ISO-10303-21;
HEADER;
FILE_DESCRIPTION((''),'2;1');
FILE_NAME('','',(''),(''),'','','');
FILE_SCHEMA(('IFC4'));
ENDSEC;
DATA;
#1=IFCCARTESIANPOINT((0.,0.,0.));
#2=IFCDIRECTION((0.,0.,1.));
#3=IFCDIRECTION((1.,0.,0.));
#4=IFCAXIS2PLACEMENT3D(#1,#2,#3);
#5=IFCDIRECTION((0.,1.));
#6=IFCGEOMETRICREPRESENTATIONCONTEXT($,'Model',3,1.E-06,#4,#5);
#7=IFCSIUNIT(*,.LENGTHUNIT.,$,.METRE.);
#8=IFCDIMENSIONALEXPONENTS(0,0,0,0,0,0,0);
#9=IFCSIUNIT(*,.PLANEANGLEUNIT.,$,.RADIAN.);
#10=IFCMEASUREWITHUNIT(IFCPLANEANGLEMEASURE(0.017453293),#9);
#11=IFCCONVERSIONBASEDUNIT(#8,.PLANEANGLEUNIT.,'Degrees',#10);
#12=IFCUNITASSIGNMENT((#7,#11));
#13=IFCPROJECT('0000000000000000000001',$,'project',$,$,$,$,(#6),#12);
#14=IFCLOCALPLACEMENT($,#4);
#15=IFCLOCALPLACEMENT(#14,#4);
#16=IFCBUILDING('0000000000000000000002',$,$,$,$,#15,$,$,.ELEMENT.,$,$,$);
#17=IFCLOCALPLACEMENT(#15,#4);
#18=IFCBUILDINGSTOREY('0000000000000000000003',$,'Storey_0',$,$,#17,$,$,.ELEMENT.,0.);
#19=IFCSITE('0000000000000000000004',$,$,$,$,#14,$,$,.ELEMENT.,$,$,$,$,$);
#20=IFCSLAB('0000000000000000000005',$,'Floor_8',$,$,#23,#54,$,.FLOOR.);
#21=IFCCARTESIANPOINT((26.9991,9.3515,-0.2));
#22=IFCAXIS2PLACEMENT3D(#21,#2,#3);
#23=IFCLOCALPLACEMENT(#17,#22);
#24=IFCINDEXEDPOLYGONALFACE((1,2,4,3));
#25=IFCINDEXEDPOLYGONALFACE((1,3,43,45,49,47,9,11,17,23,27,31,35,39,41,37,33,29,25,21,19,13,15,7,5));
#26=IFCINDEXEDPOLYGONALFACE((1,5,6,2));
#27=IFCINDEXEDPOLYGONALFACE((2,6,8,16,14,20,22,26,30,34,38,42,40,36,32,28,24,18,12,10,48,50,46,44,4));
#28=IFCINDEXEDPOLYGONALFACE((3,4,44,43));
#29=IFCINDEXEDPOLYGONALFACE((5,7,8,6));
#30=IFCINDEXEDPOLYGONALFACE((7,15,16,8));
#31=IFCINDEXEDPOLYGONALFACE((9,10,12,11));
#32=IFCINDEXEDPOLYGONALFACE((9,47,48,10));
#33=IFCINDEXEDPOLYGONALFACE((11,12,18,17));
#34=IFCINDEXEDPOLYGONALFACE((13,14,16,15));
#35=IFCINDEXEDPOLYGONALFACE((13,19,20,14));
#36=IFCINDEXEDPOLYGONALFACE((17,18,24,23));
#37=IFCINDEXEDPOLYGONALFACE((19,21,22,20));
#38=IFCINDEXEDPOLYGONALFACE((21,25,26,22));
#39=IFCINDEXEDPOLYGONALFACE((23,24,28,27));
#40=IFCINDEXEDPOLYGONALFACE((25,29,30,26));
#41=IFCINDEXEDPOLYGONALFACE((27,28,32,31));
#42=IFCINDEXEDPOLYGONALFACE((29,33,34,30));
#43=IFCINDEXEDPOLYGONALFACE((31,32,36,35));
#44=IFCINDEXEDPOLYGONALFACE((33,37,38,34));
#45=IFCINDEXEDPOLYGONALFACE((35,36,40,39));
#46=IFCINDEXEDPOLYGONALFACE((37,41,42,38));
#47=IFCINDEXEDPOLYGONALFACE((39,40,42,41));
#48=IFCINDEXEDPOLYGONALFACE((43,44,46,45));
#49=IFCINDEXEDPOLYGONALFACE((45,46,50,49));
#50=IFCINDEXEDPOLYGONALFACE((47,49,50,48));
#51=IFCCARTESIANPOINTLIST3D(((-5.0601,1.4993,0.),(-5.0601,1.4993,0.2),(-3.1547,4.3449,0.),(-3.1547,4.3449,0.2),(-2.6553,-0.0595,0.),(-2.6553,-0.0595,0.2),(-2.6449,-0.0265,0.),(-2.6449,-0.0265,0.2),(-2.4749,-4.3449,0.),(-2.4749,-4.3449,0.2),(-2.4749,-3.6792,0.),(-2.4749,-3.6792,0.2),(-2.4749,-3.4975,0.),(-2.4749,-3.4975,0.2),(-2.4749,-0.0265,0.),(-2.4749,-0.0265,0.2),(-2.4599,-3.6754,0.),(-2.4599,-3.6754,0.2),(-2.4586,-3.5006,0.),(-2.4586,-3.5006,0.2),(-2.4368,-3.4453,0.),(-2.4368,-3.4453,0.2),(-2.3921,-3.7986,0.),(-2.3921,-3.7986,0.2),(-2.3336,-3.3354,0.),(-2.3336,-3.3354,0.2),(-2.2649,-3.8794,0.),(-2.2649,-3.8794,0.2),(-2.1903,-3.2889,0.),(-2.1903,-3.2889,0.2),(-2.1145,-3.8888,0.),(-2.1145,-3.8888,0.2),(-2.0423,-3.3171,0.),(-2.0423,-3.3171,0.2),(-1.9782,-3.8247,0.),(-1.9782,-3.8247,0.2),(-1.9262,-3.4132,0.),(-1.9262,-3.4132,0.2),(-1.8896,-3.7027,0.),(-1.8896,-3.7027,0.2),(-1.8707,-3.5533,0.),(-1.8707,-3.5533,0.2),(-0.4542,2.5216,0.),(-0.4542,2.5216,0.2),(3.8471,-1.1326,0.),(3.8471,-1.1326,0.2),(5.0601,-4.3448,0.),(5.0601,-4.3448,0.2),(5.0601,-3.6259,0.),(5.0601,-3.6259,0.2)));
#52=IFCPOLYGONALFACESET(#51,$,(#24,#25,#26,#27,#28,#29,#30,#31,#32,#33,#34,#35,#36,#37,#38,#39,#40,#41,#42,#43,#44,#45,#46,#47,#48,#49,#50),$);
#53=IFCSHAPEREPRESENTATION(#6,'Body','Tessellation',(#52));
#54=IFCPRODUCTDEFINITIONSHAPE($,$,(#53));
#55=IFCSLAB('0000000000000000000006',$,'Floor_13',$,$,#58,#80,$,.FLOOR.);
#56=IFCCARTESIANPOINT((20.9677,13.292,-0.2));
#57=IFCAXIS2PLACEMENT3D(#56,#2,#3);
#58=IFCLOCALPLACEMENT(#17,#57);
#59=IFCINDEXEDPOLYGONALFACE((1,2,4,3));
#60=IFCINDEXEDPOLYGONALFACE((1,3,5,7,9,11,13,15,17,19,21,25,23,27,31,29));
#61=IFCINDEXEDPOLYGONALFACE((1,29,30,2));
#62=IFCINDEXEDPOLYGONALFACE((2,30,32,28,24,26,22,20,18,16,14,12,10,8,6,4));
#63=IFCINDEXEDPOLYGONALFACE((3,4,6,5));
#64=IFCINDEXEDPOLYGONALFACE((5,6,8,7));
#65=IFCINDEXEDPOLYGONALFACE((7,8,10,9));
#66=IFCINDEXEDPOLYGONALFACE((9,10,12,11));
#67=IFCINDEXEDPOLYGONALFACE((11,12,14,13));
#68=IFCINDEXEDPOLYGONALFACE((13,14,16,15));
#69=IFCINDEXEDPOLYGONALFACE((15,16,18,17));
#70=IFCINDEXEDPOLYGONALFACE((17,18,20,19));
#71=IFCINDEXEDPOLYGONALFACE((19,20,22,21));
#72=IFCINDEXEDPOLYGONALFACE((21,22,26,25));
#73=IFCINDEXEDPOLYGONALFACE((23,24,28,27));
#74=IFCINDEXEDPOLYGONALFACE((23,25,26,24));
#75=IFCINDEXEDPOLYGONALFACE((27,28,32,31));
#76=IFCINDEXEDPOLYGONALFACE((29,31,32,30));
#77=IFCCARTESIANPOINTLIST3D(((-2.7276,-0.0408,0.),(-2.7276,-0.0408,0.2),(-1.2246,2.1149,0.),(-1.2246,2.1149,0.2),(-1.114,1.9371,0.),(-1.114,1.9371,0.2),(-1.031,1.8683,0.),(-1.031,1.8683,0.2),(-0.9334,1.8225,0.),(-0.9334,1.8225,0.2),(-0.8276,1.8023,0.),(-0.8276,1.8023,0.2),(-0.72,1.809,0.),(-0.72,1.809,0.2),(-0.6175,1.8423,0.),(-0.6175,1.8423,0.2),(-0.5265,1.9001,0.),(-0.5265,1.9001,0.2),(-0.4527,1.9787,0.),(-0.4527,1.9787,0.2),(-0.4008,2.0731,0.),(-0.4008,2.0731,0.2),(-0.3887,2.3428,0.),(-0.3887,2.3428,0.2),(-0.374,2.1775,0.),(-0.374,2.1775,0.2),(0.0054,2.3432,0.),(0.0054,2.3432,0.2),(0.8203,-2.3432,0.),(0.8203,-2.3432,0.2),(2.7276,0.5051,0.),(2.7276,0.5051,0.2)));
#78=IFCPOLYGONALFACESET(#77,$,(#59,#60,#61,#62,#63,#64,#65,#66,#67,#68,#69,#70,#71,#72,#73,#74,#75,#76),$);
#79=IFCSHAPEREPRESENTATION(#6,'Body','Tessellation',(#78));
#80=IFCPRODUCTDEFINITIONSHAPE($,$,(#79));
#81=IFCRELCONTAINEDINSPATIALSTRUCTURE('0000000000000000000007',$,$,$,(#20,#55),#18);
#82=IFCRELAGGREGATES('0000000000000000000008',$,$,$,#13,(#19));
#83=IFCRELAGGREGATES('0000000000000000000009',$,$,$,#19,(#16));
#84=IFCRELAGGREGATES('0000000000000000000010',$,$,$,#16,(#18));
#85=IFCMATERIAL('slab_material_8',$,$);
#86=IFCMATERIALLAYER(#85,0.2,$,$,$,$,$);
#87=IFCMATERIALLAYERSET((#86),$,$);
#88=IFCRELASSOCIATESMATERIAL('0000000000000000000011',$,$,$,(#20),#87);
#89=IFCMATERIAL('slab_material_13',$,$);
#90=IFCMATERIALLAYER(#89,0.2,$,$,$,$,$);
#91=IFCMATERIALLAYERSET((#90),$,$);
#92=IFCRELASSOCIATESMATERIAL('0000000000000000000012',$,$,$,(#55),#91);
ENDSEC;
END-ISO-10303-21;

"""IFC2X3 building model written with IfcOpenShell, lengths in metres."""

from ifc_helpers import new_model, entity, si_unit, converted_unit, direction, frame, origin_with_axes, place, context, project, spatial, polyline, outline, extrude, material, layer, layer_set, layer_usage, element, save


model = new_model("IFC2X3")

# Units and contexts
model_context = context("Model", 3, precision=1e-06, world=origin_with_axes(), true_north=direction((0.0, 1.0)))
ifc_project = project(units=[si_unit("LENGTHUNIT", "METRE"), converted_unit("PLANEANGLEUNIT", "Degrees", entity("IfcPlaneAngleMeasure", 0.017453293), si_unit("PLANEANGLEUNIT", "RADIAN"), dimensions=[0, 0, 0, 0, 0, 0, 0])], contexts=[model_context])

# Site, building, storey
site_placement = place(None, origin_with_axes())
site = spatial("IfcSite", under=ifc_project, at=site_placement, CompositionType="ELEMENT")
building_placement = place(site_placement, origin_with_axes())
building = spatial("IfcBuilding", under=site, at=building_placement, CompositionType="ELEMENT")
storey_placement = place(building_placement, origin_with_axes())
storey = spatial("IfcBuildingStorey", under=building, at=storey_placement, Name="Storey_0", CompositionType="ELEMENT", Elevation=0.0)

# Slabs
ifc_material_1 = material(Name="slab_material_8")
ifc_layer_1 = layer(ifc_material_1, 0.2)
ifc_layer_set_1 = layer_set([ifc_layer_1])
ifc_layer_usage_1 = layer_usage(ifc_layer_set_1, "AXIS3", "POSITIVE", 0.0)
slab_1_placement = place(storey_placement, frame((26.9991, 9.3515, -0.2), z_axis=(0.0, 0.0, 1.0), x_axis=(1.0, 0.0, 0.0)))
element("IfcSlab", 1, at=slab_1_placement, inside=storey, material=ifc_layer_usage_1, Name="Floor_8", PredefinedType="FLOOR", context=model_context, shape_type="SweptSolid", body=[
    extrude(outline(polyline([(-0.4542, 2.5216), (3.8471, -1.1326), (5.0601, -3.6259), (5.0601, -4.3448), (-2.4749, -4.3449), (-2.4749, -3.6792), (-2.4599, -3.6754), (-2.3921, -3.7986), (-2.2649, -3.8794), (-2.1145, -3.8888), (-1.9782, -3.8247), (-1.8896, -3.7027), (-1.8707, -3.5533), (-1.9262, -3.4132), (-2.0423, -3.3171), (-2.1903, -3.2889), (-2.3336, -3.3354), (-2.4368, -3.4453), (-2.4586, -3.5006), (-2.4749, -3.4975), (-2.4749, -0.0265), (-2.6449, -0.0265), (-2.6553, -0.0595), (-5.0601, 1.4993), (-3.1547, 4.3449), (-0.4542, 2.5216)])), origin_with_axes(), (0.0, 0.0, 1.0), 0.2),
])
ifc_material_2 = material(Name="slab_material_13")
ifc_layer_2 = layer(ifc_material_2, 0.2)
ifc_layer_set_2 = layer_set([ifc_layer_2])
ifc_layer_usage_2 = layer_usage(ifc_layer_set_2, "AXIS3", "POSITIVE", 0.0)
slab_2_placement = place(storey_placement, frame((20.9677, 13.292, -0.2), z_axis=(0.0, 0.0, 1.0), x_axis=(1.0, 0.0, 0.0)))
element("IfcSlab", 2, at=slab_2_placement, inside=storey, material=ifc_layer_usage_2, Name="Floor_13", PredefinedType="FLOOR", context=model_context, shape_type="SweptSolid", body=[
    extrude(outline(polyline([(2.7276, 0.5051), (0.8203, -2.3432), (-2.7276, -0.0408), (-1.2246, 2.1149), (-1.114, 1.9371), (-1.031, 1.8683), (-0.9334, 1.8225), (-0.8276, 1.8023), (-0.72, 1.809), (-0.6175, 1.8423), (-0.5265, 1.9001), (-0.4527, 1.9787), (-0.4008, 2.0731), (-0.374, 2.1775), (-0.3887, 2.3428), (0.0054, 2.3432), (2.7276, 0.5051)])), origin_with_axes(), (0.0, 0.0, 1.0), 0.2),
])

save(model, "model.ifc")
